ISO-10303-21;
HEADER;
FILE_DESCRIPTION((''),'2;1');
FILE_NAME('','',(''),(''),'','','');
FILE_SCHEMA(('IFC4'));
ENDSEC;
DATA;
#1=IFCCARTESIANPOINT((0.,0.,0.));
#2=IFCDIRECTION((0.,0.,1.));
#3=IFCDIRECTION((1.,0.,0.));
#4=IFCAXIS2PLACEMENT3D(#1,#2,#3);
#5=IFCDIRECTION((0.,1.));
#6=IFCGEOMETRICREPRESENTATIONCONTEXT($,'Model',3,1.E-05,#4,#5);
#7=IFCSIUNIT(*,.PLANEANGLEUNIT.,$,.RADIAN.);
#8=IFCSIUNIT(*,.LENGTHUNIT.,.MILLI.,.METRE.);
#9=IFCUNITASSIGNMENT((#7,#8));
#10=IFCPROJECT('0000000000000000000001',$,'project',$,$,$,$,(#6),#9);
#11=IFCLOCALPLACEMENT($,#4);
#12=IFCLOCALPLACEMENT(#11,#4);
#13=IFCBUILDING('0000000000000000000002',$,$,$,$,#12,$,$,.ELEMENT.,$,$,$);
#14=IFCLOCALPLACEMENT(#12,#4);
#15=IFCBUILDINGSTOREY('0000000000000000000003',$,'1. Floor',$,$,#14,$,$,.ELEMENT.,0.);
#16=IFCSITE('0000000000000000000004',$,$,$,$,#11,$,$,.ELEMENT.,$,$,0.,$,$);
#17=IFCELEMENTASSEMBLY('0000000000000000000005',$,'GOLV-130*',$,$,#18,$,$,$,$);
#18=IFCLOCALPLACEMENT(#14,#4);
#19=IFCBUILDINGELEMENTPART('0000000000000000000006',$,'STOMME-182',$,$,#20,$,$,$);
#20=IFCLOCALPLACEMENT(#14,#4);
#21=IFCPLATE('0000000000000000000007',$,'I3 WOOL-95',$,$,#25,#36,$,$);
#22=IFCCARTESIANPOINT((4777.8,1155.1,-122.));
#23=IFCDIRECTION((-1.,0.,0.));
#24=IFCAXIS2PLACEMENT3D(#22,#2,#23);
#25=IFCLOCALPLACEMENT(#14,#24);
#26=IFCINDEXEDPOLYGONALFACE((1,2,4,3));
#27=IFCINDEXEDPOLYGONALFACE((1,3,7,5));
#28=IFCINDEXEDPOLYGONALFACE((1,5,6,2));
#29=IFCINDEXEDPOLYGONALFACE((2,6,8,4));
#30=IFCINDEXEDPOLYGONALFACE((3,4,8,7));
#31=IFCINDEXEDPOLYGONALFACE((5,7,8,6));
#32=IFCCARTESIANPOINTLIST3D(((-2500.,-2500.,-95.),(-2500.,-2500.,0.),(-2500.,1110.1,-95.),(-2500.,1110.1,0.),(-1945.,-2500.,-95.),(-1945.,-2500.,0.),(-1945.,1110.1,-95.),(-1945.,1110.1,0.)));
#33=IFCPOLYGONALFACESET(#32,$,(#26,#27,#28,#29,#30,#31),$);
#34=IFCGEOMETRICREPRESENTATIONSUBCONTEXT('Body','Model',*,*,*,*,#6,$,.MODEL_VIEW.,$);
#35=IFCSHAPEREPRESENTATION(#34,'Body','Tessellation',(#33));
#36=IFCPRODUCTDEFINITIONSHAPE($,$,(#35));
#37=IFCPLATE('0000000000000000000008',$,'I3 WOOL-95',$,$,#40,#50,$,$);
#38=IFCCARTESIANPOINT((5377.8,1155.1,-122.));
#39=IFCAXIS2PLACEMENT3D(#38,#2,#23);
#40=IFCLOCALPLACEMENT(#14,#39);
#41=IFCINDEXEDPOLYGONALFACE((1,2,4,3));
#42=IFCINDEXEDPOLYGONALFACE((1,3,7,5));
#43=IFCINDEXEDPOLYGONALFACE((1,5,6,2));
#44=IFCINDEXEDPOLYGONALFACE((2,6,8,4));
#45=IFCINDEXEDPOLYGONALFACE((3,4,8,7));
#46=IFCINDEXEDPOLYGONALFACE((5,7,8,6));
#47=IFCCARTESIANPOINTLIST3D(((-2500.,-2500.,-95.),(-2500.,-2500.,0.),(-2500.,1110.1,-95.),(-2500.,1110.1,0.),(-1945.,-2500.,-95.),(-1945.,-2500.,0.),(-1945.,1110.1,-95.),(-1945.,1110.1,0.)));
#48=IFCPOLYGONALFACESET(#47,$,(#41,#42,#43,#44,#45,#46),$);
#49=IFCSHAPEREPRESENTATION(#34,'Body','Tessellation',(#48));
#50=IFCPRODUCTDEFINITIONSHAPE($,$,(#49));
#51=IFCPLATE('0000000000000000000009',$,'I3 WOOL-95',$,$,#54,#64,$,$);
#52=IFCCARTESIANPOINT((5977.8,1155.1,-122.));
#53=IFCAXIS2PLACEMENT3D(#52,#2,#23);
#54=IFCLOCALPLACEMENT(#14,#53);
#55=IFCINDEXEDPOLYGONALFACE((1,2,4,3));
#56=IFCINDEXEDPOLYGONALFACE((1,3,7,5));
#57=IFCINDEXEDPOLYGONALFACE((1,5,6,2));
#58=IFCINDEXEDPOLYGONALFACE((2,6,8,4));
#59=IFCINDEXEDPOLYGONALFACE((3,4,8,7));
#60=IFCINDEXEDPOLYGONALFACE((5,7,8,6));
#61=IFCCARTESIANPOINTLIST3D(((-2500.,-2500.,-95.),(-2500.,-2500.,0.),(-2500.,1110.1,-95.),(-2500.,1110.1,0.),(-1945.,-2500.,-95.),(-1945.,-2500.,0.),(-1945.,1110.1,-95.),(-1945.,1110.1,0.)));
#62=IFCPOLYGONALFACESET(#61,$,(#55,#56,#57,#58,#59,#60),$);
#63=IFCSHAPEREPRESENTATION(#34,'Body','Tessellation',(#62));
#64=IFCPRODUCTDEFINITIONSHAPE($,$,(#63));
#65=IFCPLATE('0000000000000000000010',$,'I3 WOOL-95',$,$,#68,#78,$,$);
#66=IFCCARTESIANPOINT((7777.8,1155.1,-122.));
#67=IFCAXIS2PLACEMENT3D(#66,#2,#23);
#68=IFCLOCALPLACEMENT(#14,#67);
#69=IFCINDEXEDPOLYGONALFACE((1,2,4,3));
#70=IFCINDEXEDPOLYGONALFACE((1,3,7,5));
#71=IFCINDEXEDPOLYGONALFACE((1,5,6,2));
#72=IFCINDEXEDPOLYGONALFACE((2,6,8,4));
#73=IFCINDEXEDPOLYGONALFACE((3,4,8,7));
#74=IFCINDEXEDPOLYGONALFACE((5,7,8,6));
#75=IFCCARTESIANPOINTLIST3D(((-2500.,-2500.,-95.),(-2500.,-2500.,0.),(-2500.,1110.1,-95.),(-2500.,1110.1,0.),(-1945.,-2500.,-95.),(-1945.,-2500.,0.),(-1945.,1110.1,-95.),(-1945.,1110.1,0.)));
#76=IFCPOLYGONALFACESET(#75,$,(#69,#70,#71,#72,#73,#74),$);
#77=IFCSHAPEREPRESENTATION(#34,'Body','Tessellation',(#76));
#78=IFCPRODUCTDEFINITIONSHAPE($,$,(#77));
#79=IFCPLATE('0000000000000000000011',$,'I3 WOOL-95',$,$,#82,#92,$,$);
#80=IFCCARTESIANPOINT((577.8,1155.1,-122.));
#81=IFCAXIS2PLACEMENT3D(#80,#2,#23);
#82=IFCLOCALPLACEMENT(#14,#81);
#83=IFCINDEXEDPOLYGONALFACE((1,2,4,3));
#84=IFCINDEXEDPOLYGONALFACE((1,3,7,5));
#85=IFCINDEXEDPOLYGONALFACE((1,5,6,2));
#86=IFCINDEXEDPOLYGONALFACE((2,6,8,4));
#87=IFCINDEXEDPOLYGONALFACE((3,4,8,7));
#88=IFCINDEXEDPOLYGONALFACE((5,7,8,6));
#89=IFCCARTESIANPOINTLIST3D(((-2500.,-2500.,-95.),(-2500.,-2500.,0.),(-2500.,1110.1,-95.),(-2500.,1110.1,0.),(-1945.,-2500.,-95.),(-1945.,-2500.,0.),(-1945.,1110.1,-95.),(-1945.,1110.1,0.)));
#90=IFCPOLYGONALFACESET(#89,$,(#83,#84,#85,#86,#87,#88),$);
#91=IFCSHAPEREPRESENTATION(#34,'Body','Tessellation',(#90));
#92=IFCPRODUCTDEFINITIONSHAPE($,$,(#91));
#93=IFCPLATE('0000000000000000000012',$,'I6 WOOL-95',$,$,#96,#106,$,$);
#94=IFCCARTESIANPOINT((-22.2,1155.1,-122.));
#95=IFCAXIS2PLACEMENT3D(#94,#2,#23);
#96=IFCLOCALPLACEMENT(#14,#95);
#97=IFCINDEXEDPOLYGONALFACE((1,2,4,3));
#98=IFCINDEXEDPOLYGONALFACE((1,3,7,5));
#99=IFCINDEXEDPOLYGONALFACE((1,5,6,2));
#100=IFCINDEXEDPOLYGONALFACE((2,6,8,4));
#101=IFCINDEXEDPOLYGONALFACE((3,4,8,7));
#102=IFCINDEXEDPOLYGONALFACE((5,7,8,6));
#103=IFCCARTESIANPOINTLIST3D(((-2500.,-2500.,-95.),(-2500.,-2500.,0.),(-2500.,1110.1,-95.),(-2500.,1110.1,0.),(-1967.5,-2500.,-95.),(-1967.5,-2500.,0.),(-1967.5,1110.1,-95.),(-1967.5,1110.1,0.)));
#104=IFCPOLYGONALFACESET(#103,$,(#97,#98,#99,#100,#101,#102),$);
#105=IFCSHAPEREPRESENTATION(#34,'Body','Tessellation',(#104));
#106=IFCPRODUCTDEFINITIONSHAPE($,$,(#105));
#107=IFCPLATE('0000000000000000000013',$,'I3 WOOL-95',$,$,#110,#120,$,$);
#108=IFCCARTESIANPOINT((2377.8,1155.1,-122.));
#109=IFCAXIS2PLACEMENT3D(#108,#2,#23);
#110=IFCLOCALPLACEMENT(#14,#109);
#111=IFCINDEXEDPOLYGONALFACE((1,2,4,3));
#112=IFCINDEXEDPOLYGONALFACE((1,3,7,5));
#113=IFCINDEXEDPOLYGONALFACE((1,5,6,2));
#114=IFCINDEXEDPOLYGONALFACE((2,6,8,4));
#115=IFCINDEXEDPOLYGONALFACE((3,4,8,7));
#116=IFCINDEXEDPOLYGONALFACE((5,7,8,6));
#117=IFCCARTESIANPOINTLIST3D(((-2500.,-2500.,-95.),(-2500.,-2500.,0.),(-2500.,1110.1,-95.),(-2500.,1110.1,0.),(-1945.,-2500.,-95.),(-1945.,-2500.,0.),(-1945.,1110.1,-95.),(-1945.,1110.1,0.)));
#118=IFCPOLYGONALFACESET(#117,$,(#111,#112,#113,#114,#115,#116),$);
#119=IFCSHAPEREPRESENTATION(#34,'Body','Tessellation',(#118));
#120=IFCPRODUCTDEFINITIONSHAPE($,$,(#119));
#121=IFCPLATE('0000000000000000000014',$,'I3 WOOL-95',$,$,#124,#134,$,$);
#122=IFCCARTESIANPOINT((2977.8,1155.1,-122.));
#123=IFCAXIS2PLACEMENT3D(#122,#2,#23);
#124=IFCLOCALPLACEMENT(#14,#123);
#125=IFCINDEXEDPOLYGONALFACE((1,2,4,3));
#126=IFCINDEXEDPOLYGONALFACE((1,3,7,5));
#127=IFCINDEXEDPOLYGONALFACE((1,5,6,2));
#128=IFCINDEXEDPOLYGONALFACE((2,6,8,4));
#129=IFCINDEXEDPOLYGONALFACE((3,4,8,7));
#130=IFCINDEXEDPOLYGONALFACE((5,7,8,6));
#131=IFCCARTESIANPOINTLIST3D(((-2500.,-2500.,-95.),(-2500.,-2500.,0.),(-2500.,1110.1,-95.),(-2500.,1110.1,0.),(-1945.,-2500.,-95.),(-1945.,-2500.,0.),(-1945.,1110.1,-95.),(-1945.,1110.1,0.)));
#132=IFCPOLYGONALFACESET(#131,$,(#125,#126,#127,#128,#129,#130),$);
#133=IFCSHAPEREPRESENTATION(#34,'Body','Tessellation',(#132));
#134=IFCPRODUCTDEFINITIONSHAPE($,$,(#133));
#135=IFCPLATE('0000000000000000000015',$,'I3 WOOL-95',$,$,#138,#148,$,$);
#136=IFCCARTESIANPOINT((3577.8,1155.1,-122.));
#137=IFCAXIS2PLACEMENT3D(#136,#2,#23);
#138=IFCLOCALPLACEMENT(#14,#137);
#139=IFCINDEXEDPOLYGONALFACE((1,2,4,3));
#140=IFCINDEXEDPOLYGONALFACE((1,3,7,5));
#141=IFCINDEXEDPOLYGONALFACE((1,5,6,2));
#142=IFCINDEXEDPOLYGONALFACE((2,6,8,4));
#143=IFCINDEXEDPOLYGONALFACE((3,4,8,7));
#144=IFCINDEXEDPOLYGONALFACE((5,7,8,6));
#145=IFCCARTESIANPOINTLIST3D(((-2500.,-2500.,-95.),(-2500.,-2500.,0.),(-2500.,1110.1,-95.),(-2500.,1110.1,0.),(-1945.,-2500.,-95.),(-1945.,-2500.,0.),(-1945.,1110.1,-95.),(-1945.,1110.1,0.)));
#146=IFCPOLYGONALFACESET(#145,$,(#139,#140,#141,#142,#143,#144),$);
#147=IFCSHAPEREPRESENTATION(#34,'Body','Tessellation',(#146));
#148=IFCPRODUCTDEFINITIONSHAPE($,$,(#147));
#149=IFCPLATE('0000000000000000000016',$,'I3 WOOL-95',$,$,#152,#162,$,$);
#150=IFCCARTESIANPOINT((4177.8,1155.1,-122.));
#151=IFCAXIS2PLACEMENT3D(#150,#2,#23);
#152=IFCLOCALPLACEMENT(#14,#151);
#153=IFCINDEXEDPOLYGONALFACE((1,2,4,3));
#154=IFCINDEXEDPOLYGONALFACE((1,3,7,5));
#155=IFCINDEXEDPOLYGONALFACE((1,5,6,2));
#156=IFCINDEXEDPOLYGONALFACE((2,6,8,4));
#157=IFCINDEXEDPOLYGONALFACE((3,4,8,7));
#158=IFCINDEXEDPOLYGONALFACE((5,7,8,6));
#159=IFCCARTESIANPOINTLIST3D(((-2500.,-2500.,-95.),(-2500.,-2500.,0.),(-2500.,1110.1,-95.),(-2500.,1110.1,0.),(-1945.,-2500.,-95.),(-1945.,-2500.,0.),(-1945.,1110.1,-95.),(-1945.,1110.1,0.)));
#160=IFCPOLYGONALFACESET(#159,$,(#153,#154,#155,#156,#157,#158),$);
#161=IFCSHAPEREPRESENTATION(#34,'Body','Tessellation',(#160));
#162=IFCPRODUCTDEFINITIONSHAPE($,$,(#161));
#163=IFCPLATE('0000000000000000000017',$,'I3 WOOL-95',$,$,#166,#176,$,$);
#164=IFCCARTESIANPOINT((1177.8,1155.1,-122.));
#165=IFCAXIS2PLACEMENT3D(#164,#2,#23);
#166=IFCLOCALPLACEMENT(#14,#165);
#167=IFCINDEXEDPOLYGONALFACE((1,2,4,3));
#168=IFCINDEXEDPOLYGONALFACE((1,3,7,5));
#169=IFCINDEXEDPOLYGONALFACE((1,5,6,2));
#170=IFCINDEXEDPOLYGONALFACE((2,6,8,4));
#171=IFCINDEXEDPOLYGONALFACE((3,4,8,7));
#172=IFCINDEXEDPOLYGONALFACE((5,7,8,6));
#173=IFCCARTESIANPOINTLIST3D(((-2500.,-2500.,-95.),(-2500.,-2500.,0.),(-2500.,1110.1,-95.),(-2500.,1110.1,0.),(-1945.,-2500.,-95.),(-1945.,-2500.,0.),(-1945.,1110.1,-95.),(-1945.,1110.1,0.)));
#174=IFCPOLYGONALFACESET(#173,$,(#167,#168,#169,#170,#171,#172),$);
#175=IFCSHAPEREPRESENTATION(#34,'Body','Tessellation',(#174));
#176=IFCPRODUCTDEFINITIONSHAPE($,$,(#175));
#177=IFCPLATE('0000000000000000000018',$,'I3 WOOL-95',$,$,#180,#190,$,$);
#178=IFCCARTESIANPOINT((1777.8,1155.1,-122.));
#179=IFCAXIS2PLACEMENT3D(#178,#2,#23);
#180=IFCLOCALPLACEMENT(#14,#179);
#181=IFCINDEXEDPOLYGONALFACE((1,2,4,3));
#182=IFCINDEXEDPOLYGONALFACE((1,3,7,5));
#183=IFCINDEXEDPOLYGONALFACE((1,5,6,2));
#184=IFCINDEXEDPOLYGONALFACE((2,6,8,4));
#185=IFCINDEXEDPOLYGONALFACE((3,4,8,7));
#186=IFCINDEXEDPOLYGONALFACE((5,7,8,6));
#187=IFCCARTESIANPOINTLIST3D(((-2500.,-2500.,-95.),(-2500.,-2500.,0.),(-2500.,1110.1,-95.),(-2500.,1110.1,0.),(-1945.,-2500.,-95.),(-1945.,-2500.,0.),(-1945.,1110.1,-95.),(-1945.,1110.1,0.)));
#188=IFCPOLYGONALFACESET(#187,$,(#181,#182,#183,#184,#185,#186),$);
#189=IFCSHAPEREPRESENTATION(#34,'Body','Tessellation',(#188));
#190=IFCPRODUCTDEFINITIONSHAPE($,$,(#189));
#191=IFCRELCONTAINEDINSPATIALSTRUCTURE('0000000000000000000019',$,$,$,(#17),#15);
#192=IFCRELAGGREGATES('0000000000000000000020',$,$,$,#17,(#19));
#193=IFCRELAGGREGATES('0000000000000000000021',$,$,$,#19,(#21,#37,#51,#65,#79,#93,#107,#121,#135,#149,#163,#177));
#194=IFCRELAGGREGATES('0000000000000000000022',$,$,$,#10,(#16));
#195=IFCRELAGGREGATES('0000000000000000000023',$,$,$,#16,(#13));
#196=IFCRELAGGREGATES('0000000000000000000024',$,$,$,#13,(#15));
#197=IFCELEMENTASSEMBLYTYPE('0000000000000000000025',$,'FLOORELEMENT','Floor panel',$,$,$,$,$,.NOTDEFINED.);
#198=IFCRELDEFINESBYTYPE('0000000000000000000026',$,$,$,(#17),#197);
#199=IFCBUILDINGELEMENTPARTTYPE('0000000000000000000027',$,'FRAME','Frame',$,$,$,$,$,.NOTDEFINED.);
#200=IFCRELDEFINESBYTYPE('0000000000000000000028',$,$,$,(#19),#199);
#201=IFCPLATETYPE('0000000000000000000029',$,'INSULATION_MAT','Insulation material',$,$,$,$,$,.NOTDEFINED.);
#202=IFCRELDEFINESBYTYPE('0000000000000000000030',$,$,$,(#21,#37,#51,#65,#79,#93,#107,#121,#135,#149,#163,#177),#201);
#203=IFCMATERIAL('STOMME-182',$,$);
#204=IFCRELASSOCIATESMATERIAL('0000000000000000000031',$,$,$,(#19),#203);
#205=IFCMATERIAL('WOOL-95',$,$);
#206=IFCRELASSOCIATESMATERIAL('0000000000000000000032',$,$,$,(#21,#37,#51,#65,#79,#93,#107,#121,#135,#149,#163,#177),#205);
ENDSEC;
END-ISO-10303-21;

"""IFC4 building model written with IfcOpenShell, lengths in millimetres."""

from ifc_helpers import new_model, si_unit, direction, frame, origin_with_axes, origin_2d_with_axis, place, context, subcontext, project, spatial, rectangle, extrude, material, type_object, element, aggregate, save


model = new_model("IFC4")

# Units and contexts
model_context = context("Model", 3, precision=1e-05, world=origin_with_axes(), true_north=direction((0.0, 1.0)))
body_context = subcontext(model_context, "Body", "Model", "MODEL_VIEW")
ifc_project = project(units=[si_unit("PLANEANGLEUNIT", "RADIAN"), si_unit("LENGTHUNIT", "METRE", prefix="MILLI")], contexts=[model_context])

# Site, building, storey
site_placement = place(None, origin_with_axes())
site = spatial("IfcSite", under=ifc_project, at=site_placement, CompositionType="ELEMENT", RefElevation=0.0)
building_placement = place(site_placement, origin_with_axes())
building = spatial("IfcBuilding", under=site, at=building_placement, CompositionType="ELEMENT")
storey_placement = place(building_placement, origin_with_axes())
storey = spatial("IfcBuildingStorey", under=building, at=storey_placement, Name="1. Floor", CompositionType="ELEMENT", Elevation=0.0)

# Element assembly, building element part, plates
element_assembly_type = type_object("IfcElementAssemblyType", Name="FLOORELEMENT", Description="Floor panel", PredefinedType="NOTDEFINED")
assembly_placement = place(storey_placement, origin_with_axes())
assembly = element("IfcElementAssembly", 1, at=assembly_placement, inside=storey, type_object=element_assembly_type, Name="GOLV-130*")
ifc_material_1 = material(Name="STOMME-182")
building_element_part_type = type_object("IfcBuildingElementPartType", Name="FRAME", Description="Frame", PredefinedType="NOTDEFINED")
building_element_part_placement = place(storey_placement, origin_with_axes())
building_element_part = element("IfcBuildingElementPart", 2, at=building_element_part_placement, type_object=building_element_part_type, material=ifc_material_1, Name="STOMME-182")
aggregate(assembly, [building_element_part])
ifc_material_2 = material(Name="WOOL-95")
plate_type = type_object("IfcPlateType", Name="INSULATION_MAT", Description="Insulation material", PredefinedType="NOTDEFINED")
plate_1_placement = place(storey_placement, frame((4777.8, 1155.1, -122.0), z_axis=(0.0, 0.0, 1.0), x_axis=(-1.0, 0.0, 0.0)))
plate_1 = element("IfcPlate", 3, at=plate_1_placement, type_object=plate_type, material=ifc_material_2, Name="I3 WOOL-95", context=body_context, shape_type="SweptSolid", body=[
    extrude(rectangle(XDim=95.0, YDim=555.0, at=origin_2d_with_axis()), frame((-2222.5, -2500.0, -47.5), z_axis=(0.0, 1.0, 0.0), x_axis=(0.0, 0.0, 1.0)), (0.0, 0.0, 1.0), 3610.1),
])
plate_2_placement = place(storey_placement, frame((5377.8, 1155.1, -122.0), z_axis=(0.0, 0.0, 1.0), x_axis=(-1.0, 0.0, 0.0)))
plate_2 = element("IfcPlate", 4, at=plate_2_placement, type_object=plate_type, material=ifc_material_2, Name="I3 WOOL-95", context=body_context, shape_type="SweptSolid", body=[
    extrude(rectangle(XDim=95.0, YDim=555.0, at=origin_2d_with_axis()), frame((-2222.5, -2500.0, -47.5), z_axis=(0.0, 1.0, 0.0), x_axis=(0.0, 0.0, 1.0)), (0.0, 0.0, 1.0), 3610.1),
])
plate_3_placement = place(storey_placement, frame((5977.8, 1155.1, -122.0), z_axis=(0.0, 0.0, 1.0), x_axis=(-1.0, 0.0, 0.0)))
plate_3 = element("IfcPlate", 5, at=plate_3_placement, type_object=plate_type, material=ifc_material_2, Name="I3 WOOL-95", context=body_context, shape_type="SweptSolid", body=[
    extrude(rectangle(XDim=95.0, YDim=555.0, at=origin_2d_with_axis()), frame((-2222.5, -2500.0, -47.5), z_axis=(0.0, 1.0, 0.0), x_axis=(0.0, 0.0, 1.0)), (0.0, 0.0, 1.0), 3610.1),
])
plate_4_placement = place(storey_placement, frame((7777.8, 1155.1, -122.0), z_axis=(0.0, 0.0, 1.0), x_axis=(-1.0, 0.0, 0.0)))
plate_4 = element("IfcPlate", 6, at=plate_4_placement, type_object=plate_type, material=ifc_material_2, Name="I3 WOOL-95", context=body_context, shape_type="SweptSolid", body=[
    extrude(rectangle(XDim=95.0, YDim=555.0, at=origin_2d_with_axis()), frame((-2222.5, -2500.0, -47.5), z_axis=(0.0, 1.0, 0.0), x_axis=(0.0, 0.0, 1.0)), (0.0, 0.0, 1.0), 3610.1),
])
plate_5_placement = place(storey_placement, frame((577.8, 1155.1, -122.0), z_axis=(0.0, 0.0, 1.0), x_axis=(-1.0, 0.0, 0.0)))
plate_5 = element("IfcPlate", 7, at=plate_5_placement, type_object=plate_type, material=ifc_material_2, Name="I3 WOOL-95", context=body_context, shape_type="SweptSolid", body=[
    extrude(rectangle(XDim=95.0, YDim=555.0, at=origin_2d_with_axis()), frame((-2222.5, -2500.0, -47.5), z_axis=(0.0, 1.0, 0.0), x_axis=(0.0, 0.0, 1.0)), (0.0, 0.0, 1.0), 3610.1),
])
plate_6_placement = place(storey_placement, frame((-22.2, 1155.1, -122.0), z_axis=(0.0, 0.0, 1.0), x_axis=(-1.0, 0.0, 0.0)))
plate_6 = element("IfcPlate", 8, at=plate_6_placement, type_object=plate_type, material=ifc_material_2, Name="I6 WOOL-95", context=body_context, shape_type="SweptSolid", body=[
    extrude(rectangle(XDim=95.0, YDim=532.5, at=origin_2d_with_axis()), frame((-2233.8, -2500.0, -47.5), z_axis=(0.0, 1.0, 0.0), x_axis=(0.0, 0.0, 1.0)), (0.0, 0.0, 1.0), 3610.1),
])
plate_7_placement = place(storey_placement, frame((2377.8, 1155.1, -122.0), z_axis=(0.0, 0.0, 1.0), x_axis=(-1.0, 0.0, 0.0)))
plate_7 = element("IfcPlate", 9, at=plate_7_placement, type_object=plate_type, material=ifc_material_2, Name="I3 WOOL-95", context=body_context, shape_type="SweptSolid", body=[
    extrude(rectangle(XDim=95.0, YDim=555.0, at=origin_2d_with_axis()), frame((-2222.5, -2500.0, -47.5), z_axis=(0.0, 1.0, 0.0), x_axis=(0.0, 0.0, 1.0)), (0.0, 0.0, 1.0), 3610.1),
])
plate_8_placement = place(storey_placement, frame((2977.8, 1155.1, -122.0), z_axis=(0.0, 0.0, 1.0), x_axis=(-1.0, 0.0, 0.0)))
plate_8 = element("IfcPlate", 10, at=plate_8_placement, type_object=plate_type, material=ifc_material_2, Name="I3 WOOL-95", context=body_context, shape_type="SweptSolid", body=[
    extrude(rectangle(XDim=95.0, YDim=555.0, at=origin_2d_with_axis()), frame((-2222.5, -2500.0, -47.5), z_axis=(0.0, 1.0, 0.0), x_axis=(0.0, 0.0, 1.0)), (0.0, 0.0, 1.0), 3610.1),
])
plate_9_placement = place(storey_placement, frame((3577.8, 1155.1, -122.0), z_axis=(0.0, 0.0, 1.0), x_axis=(-1.0, 0.0, 0.0)))
plate_9 = element("IfcPlate", 11, at=plate_9_placement, type_object=plate_type, material=ifc_material_2, Name="I3 WOOL-95", context=body_context, shape_type="SweptSolid", body=[
    extrude(rectangle(XDim=95.0, YDim=555.0, at=origin_2d_with_axis()), frame((-2222.5, -2500.0, -47.5), z_axis=(0.0, 1.0, 0.0), x_axis=(0.0, 0.0, 1.0)), (0.0, 0.0, 1.0), 3610.1),
])
plate_10_placement = place(storey_placement, frame((4177.8, 1155.1, -122.0), z_axis=(0.0, 0.0, 1.0), x_axis=(-1.0, 0.0, 0.0)))
plate_10 = element("IfcPlate", 12, at=plate_10_placement, type_object=plate_type, material=ifc_material_2, Name="I3 WOOL-95", context=body_context, shape_type="SweptSolid", body=[
    extrude(rectangle(XDim=95.0, YDim=555.0, at=origin_2d_with_axis()), frame((-2222.5, -2500.0, -47.5), z_axis=(0.0, 1.0, 0.0), x_axis=(0.0, 0.0, 1.0)), (0.0, 0.0, 1.0), 3610.1),
])
plate_11_placement = place(storey_placement, frame((1177.8, 1155.1, -122.0), z_axis=(0.0, 0.0, 1.0), x_axis=(-1.0, 0.0, 0.0)))
plate_11 = element("IfcPlate", 13, at=plate_11_placement, type_object=plate_type, material=ifc_material_2, Name="I3 WOOL-95", context=body_context, shape_type="SweptSolid", body=[
    extrude(rectangle(XDim=95.0, YDim=555.0, at=origin_2d_with_axis()), frame((-2222.5, -2500.0, -47.5), z_axis=(0.0, 1.0, 0.0), x_axis=(0.0, 0.0, 1.0)), (0.0, 0.0, 1.0), 3610.1),
])
plate_12_placement = place(storey_placement, frame((1777.8, 1155.1, -122.0), z_axis=(0.0, 0.0, 1.0), x_axis=(-1.0, 0.0, 0.0)))
plate_12 = element("IfcPlate", 14, at=plate_12_placement, type_object=plate_type, material=ifc_material_2, Name="I3 WOOL-95", context=body_context, shape_type="SweptSolid", body=[
    extrude(rectangle(XDim=95.0, YDim=555.0, at=origin_2d_with_axis()), frame((-2222.5, -2500.0, -47.5), z_axis=(0.0, 1.0, 0.0), x_axis=(0.0, 0.0, 1.0)), (0.0, 0.0, 1.0), 3610.1),
])
aggregate(building_element_part, [plate_1, plate_2, plate_3, plate_4, plate_5, plate_6, plate_7, plate_8, plate_9, plate_10, plate_11, plate_12])

save(model, "model.ifc")
